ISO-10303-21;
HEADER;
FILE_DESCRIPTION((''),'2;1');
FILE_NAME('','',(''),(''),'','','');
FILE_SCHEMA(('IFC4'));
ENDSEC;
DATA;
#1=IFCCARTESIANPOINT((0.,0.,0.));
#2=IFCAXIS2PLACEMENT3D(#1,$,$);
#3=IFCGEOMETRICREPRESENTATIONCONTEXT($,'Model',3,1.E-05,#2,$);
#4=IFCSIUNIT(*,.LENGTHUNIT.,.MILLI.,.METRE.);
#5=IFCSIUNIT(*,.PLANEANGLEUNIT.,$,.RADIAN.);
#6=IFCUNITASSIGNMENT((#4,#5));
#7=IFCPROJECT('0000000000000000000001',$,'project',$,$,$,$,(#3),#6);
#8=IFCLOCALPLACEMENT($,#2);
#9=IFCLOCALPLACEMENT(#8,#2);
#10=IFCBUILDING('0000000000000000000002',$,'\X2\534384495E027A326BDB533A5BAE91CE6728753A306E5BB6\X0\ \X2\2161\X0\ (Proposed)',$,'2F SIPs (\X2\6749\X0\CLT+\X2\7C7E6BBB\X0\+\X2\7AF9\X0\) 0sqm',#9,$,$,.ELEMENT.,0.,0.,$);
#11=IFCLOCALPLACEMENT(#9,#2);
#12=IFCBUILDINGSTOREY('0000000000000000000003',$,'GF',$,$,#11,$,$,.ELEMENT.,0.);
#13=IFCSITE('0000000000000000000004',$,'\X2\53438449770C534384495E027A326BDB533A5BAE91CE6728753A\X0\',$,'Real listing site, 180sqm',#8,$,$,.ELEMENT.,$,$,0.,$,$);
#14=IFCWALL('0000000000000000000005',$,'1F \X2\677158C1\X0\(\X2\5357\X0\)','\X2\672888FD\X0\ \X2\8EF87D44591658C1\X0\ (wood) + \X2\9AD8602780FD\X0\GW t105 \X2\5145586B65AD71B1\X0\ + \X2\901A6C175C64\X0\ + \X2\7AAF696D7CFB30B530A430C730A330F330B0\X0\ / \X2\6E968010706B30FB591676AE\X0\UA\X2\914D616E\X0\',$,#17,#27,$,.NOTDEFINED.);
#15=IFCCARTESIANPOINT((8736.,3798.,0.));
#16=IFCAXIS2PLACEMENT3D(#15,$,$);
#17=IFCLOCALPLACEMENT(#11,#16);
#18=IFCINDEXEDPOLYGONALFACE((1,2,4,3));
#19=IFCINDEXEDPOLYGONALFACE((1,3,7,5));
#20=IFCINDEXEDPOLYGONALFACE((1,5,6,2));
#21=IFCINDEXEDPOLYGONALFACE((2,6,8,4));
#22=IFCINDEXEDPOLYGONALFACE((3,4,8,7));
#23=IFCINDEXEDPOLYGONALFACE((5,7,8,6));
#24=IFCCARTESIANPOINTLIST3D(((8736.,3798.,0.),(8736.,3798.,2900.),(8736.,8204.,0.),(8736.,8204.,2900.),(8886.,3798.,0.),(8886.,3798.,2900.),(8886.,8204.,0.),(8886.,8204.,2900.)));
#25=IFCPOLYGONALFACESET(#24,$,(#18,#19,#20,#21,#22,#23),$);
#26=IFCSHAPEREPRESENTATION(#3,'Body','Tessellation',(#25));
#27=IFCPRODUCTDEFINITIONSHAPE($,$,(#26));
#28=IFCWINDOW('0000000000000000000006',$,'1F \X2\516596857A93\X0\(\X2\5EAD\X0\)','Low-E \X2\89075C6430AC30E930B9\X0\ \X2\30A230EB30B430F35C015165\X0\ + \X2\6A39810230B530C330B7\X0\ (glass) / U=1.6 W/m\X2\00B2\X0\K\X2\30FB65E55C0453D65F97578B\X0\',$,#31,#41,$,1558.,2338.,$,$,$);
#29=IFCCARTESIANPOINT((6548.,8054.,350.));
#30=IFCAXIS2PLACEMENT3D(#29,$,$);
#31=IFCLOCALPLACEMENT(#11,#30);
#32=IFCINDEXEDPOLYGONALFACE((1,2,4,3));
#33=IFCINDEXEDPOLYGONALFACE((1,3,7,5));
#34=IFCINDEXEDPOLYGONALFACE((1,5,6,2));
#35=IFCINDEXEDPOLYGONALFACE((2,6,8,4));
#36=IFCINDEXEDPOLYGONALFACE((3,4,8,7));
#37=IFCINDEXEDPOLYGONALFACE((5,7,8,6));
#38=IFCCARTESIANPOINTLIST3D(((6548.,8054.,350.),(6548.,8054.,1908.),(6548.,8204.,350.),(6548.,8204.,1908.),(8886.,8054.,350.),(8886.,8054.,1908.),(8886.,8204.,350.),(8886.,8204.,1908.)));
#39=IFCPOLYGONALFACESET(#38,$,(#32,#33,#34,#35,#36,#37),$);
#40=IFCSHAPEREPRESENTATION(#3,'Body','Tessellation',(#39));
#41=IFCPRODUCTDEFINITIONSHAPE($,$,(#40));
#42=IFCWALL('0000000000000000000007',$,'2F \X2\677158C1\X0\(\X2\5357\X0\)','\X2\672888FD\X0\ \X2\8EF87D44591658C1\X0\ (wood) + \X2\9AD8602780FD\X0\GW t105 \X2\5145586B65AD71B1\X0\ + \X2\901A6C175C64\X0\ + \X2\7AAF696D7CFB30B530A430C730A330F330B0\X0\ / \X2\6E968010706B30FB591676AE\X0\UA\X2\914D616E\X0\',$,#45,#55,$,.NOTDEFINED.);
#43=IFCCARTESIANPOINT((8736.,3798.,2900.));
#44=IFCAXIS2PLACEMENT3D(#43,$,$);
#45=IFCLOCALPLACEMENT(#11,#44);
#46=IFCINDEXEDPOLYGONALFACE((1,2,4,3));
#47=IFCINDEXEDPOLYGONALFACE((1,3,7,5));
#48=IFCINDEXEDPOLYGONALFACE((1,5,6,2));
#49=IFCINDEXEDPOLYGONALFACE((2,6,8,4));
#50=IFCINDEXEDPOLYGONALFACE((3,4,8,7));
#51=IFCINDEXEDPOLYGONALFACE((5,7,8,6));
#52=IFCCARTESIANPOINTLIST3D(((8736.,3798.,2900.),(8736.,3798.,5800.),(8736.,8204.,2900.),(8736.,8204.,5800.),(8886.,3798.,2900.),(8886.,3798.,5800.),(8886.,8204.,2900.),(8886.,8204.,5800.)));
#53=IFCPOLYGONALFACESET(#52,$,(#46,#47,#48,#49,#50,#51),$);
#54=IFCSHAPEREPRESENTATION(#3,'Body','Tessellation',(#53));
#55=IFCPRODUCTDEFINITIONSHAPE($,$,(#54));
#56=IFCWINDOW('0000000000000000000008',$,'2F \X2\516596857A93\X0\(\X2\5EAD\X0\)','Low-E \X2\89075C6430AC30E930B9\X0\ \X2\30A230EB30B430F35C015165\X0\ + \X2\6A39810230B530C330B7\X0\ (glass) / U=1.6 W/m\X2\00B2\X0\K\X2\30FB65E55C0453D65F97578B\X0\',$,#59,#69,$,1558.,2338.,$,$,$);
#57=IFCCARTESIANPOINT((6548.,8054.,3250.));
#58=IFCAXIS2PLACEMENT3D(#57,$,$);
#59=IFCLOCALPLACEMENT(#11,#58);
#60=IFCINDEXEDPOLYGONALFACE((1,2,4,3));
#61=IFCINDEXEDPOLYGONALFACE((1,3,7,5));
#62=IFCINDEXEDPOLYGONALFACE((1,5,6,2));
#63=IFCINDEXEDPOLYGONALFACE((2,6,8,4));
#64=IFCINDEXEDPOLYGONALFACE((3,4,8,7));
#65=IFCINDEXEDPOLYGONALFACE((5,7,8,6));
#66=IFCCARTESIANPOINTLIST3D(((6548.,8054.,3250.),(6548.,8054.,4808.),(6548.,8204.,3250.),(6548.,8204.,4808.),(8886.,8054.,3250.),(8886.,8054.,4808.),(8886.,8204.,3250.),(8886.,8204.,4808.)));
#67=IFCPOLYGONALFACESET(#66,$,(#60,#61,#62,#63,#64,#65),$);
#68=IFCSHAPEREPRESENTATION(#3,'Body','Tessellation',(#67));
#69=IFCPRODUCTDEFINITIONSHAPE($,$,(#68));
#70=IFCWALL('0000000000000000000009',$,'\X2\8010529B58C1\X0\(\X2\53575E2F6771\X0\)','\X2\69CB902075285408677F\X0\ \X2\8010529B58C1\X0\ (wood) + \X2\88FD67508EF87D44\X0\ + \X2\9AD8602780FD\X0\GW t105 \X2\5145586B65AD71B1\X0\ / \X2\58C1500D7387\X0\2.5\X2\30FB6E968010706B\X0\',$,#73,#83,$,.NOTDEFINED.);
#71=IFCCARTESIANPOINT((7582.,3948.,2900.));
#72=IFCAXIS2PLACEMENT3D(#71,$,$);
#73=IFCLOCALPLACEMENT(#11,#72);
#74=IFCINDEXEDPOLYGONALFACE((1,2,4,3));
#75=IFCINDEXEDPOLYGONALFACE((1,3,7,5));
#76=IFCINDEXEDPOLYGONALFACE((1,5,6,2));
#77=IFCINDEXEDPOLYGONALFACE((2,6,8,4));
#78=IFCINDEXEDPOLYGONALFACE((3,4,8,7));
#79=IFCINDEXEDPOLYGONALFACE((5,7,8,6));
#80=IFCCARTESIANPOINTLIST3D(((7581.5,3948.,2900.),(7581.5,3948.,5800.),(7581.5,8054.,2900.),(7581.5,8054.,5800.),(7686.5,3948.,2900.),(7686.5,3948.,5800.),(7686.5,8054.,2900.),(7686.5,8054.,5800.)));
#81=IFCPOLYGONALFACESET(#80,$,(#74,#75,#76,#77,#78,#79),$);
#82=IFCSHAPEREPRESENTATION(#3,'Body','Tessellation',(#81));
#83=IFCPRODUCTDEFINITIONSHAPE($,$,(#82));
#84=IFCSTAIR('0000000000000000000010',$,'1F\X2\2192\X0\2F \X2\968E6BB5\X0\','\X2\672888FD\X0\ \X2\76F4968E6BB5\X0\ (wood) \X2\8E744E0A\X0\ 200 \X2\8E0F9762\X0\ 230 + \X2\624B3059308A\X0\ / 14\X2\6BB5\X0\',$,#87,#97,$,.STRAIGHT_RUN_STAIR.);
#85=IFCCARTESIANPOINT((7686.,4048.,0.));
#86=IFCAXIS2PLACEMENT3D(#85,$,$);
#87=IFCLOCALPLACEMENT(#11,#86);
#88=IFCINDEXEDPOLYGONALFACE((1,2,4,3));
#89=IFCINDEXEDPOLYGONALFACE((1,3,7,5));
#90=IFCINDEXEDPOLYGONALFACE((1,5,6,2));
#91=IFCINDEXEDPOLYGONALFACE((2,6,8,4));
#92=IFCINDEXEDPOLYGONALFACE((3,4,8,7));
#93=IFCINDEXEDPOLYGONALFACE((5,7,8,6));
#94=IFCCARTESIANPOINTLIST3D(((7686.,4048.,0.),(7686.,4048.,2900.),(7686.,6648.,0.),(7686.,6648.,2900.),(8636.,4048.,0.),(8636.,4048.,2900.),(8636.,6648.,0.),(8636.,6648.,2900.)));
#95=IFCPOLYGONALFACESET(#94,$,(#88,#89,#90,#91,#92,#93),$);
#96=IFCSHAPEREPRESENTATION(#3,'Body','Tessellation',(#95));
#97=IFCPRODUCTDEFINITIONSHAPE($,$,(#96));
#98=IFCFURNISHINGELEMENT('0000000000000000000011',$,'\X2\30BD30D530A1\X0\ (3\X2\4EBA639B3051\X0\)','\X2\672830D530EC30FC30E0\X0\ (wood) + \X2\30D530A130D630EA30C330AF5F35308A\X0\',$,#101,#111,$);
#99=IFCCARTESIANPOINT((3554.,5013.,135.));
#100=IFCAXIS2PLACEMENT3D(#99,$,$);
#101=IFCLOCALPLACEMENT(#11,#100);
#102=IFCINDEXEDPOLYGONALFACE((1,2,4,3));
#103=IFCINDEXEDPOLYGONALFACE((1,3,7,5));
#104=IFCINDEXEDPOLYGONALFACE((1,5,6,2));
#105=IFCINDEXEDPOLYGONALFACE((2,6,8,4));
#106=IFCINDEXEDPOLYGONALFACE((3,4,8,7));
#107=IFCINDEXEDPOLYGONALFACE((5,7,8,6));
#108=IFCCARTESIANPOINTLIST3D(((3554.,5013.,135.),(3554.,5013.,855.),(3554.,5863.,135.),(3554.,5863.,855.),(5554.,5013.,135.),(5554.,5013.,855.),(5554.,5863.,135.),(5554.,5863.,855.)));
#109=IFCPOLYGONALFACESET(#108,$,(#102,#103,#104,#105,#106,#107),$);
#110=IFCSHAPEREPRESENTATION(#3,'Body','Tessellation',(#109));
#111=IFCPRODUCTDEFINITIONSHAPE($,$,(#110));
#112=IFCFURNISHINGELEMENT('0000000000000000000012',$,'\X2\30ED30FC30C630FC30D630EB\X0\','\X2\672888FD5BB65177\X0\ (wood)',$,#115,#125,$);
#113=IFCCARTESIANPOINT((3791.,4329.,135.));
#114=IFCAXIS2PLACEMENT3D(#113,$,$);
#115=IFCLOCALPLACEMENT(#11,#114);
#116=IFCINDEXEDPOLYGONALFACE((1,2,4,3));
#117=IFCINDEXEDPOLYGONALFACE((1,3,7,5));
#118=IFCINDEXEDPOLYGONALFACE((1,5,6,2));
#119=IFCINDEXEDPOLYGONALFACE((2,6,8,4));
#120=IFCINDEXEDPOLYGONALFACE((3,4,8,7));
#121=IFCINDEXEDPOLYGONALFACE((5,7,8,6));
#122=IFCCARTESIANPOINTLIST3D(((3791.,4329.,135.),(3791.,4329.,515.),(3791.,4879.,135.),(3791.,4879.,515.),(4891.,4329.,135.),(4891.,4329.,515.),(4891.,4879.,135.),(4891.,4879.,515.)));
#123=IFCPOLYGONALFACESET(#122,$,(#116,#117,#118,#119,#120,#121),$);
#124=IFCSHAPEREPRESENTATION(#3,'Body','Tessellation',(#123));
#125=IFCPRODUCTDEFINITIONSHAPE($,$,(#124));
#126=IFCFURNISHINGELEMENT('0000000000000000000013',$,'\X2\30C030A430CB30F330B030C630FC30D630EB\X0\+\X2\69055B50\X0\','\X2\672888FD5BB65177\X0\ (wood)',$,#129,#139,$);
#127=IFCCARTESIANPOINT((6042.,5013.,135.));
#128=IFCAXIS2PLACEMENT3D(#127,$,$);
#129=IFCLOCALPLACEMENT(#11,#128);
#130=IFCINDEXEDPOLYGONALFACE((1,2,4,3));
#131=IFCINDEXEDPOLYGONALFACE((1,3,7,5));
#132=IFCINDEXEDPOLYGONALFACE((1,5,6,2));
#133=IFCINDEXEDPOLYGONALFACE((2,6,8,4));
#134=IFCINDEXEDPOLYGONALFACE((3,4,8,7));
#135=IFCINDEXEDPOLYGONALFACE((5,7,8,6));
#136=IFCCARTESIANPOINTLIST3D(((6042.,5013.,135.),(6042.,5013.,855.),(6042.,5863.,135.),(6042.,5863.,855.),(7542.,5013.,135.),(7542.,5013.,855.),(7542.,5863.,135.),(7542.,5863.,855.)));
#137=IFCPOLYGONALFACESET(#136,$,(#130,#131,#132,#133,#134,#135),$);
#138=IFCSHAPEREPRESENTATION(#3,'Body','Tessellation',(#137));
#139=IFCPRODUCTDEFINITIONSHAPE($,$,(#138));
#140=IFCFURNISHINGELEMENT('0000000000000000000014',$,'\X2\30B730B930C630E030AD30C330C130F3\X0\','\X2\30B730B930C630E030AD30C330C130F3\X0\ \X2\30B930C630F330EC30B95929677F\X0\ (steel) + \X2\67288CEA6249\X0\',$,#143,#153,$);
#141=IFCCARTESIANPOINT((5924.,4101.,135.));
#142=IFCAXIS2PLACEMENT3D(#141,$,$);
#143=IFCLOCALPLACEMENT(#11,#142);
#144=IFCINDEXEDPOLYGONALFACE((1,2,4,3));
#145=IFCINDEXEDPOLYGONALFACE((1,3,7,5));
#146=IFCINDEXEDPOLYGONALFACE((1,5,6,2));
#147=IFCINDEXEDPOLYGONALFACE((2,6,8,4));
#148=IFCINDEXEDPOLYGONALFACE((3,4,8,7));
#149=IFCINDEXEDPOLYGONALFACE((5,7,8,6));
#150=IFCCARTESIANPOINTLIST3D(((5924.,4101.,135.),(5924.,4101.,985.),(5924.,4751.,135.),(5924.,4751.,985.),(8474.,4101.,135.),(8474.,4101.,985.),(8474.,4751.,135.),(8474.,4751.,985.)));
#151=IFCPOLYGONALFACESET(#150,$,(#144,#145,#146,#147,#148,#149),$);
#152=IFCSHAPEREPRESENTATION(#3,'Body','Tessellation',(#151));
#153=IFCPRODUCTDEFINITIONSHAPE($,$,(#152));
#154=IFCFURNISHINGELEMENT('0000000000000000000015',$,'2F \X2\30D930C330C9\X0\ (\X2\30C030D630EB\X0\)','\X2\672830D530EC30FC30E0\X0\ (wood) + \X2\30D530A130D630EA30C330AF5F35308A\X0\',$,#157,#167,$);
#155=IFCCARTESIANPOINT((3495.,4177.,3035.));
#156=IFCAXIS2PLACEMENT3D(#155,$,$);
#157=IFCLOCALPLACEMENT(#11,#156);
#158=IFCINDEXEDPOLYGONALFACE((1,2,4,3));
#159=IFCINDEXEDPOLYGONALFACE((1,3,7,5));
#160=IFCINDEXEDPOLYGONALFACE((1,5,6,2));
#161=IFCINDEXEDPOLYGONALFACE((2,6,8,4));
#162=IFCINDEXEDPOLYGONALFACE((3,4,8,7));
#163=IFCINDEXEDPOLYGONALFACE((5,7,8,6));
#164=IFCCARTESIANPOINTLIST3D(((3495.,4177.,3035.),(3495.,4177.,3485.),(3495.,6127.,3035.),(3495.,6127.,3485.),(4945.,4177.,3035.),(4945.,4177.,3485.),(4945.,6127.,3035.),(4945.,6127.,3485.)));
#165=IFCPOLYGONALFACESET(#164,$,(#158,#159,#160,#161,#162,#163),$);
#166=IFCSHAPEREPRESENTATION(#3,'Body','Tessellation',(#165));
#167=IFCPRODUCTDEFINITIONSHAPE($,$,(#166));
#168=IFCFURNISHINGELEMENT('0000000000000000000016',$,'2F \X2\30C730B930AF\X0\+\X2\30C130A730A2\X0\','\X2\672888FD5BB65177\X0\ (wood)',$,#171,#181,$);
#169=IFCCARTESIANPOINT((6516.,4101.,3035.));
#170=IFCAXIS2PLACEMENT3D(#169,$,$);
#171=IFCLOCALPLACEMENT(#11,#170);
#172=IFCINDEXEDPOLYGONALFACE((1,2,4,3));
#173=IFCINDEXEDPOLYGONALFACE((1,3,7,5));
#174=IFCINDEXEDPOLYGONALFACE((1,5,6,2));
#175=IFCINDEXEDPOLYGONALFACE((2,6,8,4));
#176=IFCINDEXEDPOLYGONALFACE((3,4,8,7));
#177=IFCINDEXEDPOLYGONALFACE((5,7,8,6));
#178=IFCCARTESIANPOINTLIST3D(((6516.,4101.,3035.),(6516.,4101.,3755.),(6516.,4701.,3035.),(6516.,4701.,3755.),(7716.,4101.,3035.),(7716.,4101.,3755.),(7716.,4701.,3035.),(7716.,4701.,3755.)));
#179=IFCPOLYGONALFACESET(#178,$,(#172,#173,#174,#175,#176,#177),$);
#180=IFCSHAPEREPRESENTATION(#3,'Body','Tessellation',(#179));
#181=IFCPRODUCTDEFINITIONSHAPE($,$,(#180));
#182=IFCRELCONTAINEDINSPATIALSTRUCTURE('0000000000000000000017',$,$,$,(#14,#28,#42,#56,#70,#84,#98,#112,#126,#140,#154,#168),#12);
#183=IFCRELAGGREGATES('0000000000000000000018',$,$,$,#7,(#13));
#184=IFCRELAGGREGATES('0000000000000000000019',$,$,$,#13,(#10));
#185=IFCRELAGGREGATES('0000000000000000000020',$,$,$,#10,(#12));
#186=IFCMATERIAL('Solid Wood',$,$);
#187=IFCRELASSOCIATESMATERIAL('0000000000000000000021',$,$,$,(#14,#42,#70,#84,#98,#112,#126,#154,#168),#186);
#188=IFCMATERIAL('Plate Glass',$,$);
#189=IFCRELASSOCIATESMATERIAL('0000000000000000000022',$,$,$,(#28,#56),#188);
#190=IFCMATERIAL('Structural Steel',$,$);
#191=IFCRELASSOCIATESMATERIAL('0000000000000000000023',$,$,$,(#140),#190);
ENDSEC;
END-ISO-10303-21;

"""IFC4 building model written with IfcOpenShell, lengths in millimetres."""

from ifc_helpers import new_model, si_unit, frame, frame_2d, origin, place, context, project, spatial, rectangle, extrude, material, element, fill, save


model = new_model("IFC4")

# Units and contexts
model_context = context("Model", 3, precision=1e-05, world=origin())
ifc_project = project(units=[si_unit("LENGTHUNIT", "METRE", prefix="MILLI"), si_unit("PLANEANGLEUNIT", "RADIAN")], contexts=[model_context])

# Site, building, storey
site_placement = place(None, origin())
site = spatial("IfcSite", under=ifc_project, at=site_placement, Name="千葉県千葉市稲毛区宮野木町", ObjectType="Real listing site, 180sqm", CompositionType="ELEMENT", RefElevation=0.0)
building_placement = place(site_placement, origin())
building = spatial("IfcBuilding", under=site, at=building_placement, Name="千葉市稲毛区宮野木町の家 Ⅱ (Proposed)", ObjectType="2F SIPs (杉CLT+籾殻+竹) 0sqm", CompositionType="ELEMENT", ElevationOfRefHeight=0.0, ElevationOfTerrain=0.0)
storey_placement = place(building_placement, origin())
storey = spatial("IfcBuildingStorey", under=building, at=storey_placement, Name="GF", CompositionType="ELEMENT", Elevation=0.0)

# Wall, opening, window
ifc_material_1 = material(Name="Solid Wood")
wall_1_placement = place(storey_placement, frame((8736.0, 3798.0, 0.0)))
wall_1 = element("IfcWall", 1, at=wall_1_placement, inside=storey, material=ifc_material_1, Name="1F 東壁(南)", Description="木製 軸組外壁 (wood) + 高性能GW t105 充填断熱 + 通気層 + 窯業系サイディング / 準耐火・外皮UA配慮", PredefinedType="NOTDEFINED", context=model_context, shape_type="SweptSolid", body=[
    extrude(rectangle(XDim=150.0, YDim=4406.0, at=frame_2d((75.0, 2203.0))), frame((8736.0, 3798.0, 0.0)), (0.0, 0.0, 1.0), 2900.0),
])
opening_1_placement = place(storey_placement, frame((6548.0, 8054.0, 350.0)))
opening_1 = element("IfcOpeningElement", 2, at=opening_1_placement, cuts=wall_1, PredefinedType="NOTDEFINED", context=model_context, shape_type="SweptSolid", body=[
    extrude(rectangle(XDim=2338.0, YDim=150.0, at=frame_2d((1169.0, 75.0))), frame((6548.0, 8054.0, 350.0)), (0.0, 0.0, 1.0), 1558.0),
])
ifc_material_2 = material(Name="Plate Glass")
window_1_placement = place(storey_placement, frame((6548.0, 8054.0, 350.0)))
window_1 = element("IfcWindow", 3, at=window_1_placement, inside=storey, material=ifc_material_2, Name="1F 入隅窓(庭)", Description="Low-E 複層ガラス アルゴン封入 + 樹脂サッシ (glass) / U=1.6 W/m²K・日射取得型", OverallHeight=1558.0, OverallWidth=2338.0, context=model_context, shape_type="SweptSolid", body=[
    extrude(rectangle(XDim=2338.0, YDim=150.0, at=frame_2d((1169.0, 75.0))), frame((6548.0, 8054.0, 350.0)), (0.0, 0.0, 1.0), 1558.0),
])
fill(opening_1, window_1)

# Wall, opening, window
wall_2_placement = place(storey_placement, frame((8736.0, 3798.0, 2900.0)))
wall_2 = element("IfcWall", 4, at=wall_2_placement, inside=storey, material=ifc_material_1, Name="2F 東壁(南)", Description="木製 軸組外壁 (wood) + 高性能GW t105 充填断熱 + 通気層 + 窯業系サイディング / 準耐火・外皮UA配慮", PredefinedType="NOTDEFINED", context=model_context, shape_type="SweptSolid", body=[
    extrude(rectangle(XDim=150.0, YDim=4406.0, at=frame_2d((75.0, 2203.0))), frame((8736.0, 3798.0, 2900.0)), (0.0, 0.0, 1.0), 2900.0),
])
opening_2_placement = place(storey_placement, frame((6548.0, 8054.0, 3250.0)))
opening_2 = element("IfcOpeningElement", 5, at=opening_2_placement, cuts=wall_2, PredefinedType="NOTDEFINED", context=model_context, shape_type="SweptSolid", body=[
    extrude(rectangle(XDim=2338.0, YDim=150.0, at=frame_2d((1169.0, 75.0))), frame((6548.0, 8054.0, 3250.0)), (0.0, 0.0, 1.0), 1558.0),
])
window_2_placement = place(storey_placement, frame((6548.0, 8054.0, 3250.0)))
window_2 = element("IfcWindow", 6, at=window_2_placement, inside=storey, material=ifc_material_2, Name="2F 入隅窓(庭)", Description="Low-E 複層ガラス アルゴン封入 + 樹脂サッシ (glass) / U=1.6 W/m²K・日射取得型", OverallHeight=1558.0, OverallWidth=2338.0, context=model_context, shape_type="SweptSolid", body=[
    extrude(rectangle(XDim=2338.0, YDim=150.0, at=frame_2d((1169.0, 75.0))), frame((6548.0, 8054.0, 3250.0)), (0.0, 0.0, 1.0), 1558.0),
])
fill(opening_2, window_2)

# Wall
wall_3_placement = place(storey_placement, frame((7582.0, 3948.0, 2900.0)))
element("IfcWall", 7, at=wall_3_placement, inside=storey, material=ifc_material_1, Name="耐力壁(南帯東)", Description="構造用合板 耐力壁 (wood) + 製材軸組 + 高性能GW t105 充填断熱 / 壁倍率2.5・準耐火", PredefinedType="NOTDEFINED", context=model_context, shape_type="SweptSolid", body=[
    extrude(rectangle(XDim=105.0, YDim=4106.0, at=frame_2d((52.0, 2053.0))), frame((7582.0, 3948.0, 2900.0)), (0.0, 0.0, 1.0), 2900.0),
])

# Stair
stair_placement = place(storey_placement, frame((7686.0, 4048.0, 0.0)))
element("IfcStair", 8, at=stair_placement, inside=storey, material=ifc_material_1, Name="1F→2F 階段", Description="木製 直階段 (wood) 蹴上 200 踏面 230 + 手すり / 14段", PredefinedType="STRAIGHT_RUN_STAIR", context=model_context, shape_type="SweptSolid", body=[
    extrude(rectangle(XDim=950.0, YDim=2600.0, at=frame_2d((475.0, 1300.0))), frame((7686.0, 4048.0, 0.0)), (0.0, 0.0, 1.0), 2900.0),
])

# Furnishing elements
furnishing_1_placement = place(storey_placement, frame((3554.0, 5013.0, 135.0)))
element("IfcFurnishingElement", 9, at=furnishing_1_placement, inside=storey, material=ifc_material_1, Name="ソファ (3人掛け)", Description="木フレーム (wood) + ファブリック張り", context=model_context, shape_type="SweptSolid", body=[
    extrude(rectangle(XDim=2000.0, YDim=850.0, at=frame_2d((1000.0, 425.0))), frame((3554.0, 5013.0, 135.0)), (0.0, 0.0, 1.0), 720.0),
])
furnishing_2_placement = place(storey_placement, frame((3791.0, 4329.0, 135.0)))
element("IfcFurnishingElement", 10, at=furnishing_2_placement, inside=storey, material=ifc_material_1, Name="ローテーブル", Description="木製家具 (wood)", context=model_context, shape_type="SweptSolid", body=[
    extrude(rectangle(XDim=1100.0, YDim=550.0, at=frame_2d((550.0, 275.0))), frame((3791.0, 4329.0, 135.0)), (0.0, 0.0, 1.0), 380.0),
])
furnishing_3_placement = place(storey_placement, frame((6042.0, 5013.0, 135.0)))
element("IfcFurnishingElement", 11, at=furnishing_3_placement, inside=storey, material=ifc_material_1, Name="ダイニングテーブル+椅子", Description="木製家具 (wood)", context=model_context, shape_type="SweptSolid", body=[
    extrude(rectangle(XDim=1500.0, YDim=850.0, at=frame_2d((750.0, 425.0))), frame((6042.0, 5013.0, 135.0)), (0.0, 0.0, 1.0), 720.0),
])
ifc_material_3 = material(Name="Structural Steel")
furnishing_4_placement = place(storey_placement, frame((5924.0, 4101.0, 135.0)))
element("IfcFurnishingElement", 12, at=furnishing_4_placement, inside=storey, material=ifc_material_3, Name="システムキッチン", Description="システムキッチン ステンレス天板 (steel) + 木質扉", context=model_context, shape_type="SweptSolid", body=[
    extrude(rectangle(XDim=2550.0, YDim=650.0, at=frame_2d((1275.0, 325.0))), frame((5924.0, 4101.0, 135.0)), (0.0, 0.0, 1.0), 850.0),
])
furnishing_5_placement = place(storey_placement, frame((3495.0, 4177.0, 3035.0)))
element("IfcFurnishingElement", 13, at=furnishing_5_placement, inside=storey, material=ifc_material_1, Name="2F ベッド (ダブル)", Description="木フレーム (wood) + ファブリック張り", context=model_context, shape_type="SweptSolid", body=[
    extrude(rectangle(XDim=1450.0, YDim=1950.0, at=frame_2d((725.0, 975.0))), frame((3495.0, 4177.0, 3035.0)), (0.0, 0.0, 1.0), 450.0),
])
furnishing_6_placement = place(storey_placement, frame((6516.0, 4101.0, 3035.0)))
element("IfcFurnishingElement", 14, at=furnishing_6_placement, inside=storey, material=ifc_material_1, Name="2F デスク+チェア", Description="木製家具 (wood)", context=model_context, shape_type="SweptSolid", body=[
    extrude(rectangle(XDim=1200.0, YDim=600.0, at=frame_2d((600.0, 300.0))), frame((6516.0, 4101.0, 3035.0)), (0.0, 0.0, 1.0), 720.0),
])

save(model, "model.ifc")
